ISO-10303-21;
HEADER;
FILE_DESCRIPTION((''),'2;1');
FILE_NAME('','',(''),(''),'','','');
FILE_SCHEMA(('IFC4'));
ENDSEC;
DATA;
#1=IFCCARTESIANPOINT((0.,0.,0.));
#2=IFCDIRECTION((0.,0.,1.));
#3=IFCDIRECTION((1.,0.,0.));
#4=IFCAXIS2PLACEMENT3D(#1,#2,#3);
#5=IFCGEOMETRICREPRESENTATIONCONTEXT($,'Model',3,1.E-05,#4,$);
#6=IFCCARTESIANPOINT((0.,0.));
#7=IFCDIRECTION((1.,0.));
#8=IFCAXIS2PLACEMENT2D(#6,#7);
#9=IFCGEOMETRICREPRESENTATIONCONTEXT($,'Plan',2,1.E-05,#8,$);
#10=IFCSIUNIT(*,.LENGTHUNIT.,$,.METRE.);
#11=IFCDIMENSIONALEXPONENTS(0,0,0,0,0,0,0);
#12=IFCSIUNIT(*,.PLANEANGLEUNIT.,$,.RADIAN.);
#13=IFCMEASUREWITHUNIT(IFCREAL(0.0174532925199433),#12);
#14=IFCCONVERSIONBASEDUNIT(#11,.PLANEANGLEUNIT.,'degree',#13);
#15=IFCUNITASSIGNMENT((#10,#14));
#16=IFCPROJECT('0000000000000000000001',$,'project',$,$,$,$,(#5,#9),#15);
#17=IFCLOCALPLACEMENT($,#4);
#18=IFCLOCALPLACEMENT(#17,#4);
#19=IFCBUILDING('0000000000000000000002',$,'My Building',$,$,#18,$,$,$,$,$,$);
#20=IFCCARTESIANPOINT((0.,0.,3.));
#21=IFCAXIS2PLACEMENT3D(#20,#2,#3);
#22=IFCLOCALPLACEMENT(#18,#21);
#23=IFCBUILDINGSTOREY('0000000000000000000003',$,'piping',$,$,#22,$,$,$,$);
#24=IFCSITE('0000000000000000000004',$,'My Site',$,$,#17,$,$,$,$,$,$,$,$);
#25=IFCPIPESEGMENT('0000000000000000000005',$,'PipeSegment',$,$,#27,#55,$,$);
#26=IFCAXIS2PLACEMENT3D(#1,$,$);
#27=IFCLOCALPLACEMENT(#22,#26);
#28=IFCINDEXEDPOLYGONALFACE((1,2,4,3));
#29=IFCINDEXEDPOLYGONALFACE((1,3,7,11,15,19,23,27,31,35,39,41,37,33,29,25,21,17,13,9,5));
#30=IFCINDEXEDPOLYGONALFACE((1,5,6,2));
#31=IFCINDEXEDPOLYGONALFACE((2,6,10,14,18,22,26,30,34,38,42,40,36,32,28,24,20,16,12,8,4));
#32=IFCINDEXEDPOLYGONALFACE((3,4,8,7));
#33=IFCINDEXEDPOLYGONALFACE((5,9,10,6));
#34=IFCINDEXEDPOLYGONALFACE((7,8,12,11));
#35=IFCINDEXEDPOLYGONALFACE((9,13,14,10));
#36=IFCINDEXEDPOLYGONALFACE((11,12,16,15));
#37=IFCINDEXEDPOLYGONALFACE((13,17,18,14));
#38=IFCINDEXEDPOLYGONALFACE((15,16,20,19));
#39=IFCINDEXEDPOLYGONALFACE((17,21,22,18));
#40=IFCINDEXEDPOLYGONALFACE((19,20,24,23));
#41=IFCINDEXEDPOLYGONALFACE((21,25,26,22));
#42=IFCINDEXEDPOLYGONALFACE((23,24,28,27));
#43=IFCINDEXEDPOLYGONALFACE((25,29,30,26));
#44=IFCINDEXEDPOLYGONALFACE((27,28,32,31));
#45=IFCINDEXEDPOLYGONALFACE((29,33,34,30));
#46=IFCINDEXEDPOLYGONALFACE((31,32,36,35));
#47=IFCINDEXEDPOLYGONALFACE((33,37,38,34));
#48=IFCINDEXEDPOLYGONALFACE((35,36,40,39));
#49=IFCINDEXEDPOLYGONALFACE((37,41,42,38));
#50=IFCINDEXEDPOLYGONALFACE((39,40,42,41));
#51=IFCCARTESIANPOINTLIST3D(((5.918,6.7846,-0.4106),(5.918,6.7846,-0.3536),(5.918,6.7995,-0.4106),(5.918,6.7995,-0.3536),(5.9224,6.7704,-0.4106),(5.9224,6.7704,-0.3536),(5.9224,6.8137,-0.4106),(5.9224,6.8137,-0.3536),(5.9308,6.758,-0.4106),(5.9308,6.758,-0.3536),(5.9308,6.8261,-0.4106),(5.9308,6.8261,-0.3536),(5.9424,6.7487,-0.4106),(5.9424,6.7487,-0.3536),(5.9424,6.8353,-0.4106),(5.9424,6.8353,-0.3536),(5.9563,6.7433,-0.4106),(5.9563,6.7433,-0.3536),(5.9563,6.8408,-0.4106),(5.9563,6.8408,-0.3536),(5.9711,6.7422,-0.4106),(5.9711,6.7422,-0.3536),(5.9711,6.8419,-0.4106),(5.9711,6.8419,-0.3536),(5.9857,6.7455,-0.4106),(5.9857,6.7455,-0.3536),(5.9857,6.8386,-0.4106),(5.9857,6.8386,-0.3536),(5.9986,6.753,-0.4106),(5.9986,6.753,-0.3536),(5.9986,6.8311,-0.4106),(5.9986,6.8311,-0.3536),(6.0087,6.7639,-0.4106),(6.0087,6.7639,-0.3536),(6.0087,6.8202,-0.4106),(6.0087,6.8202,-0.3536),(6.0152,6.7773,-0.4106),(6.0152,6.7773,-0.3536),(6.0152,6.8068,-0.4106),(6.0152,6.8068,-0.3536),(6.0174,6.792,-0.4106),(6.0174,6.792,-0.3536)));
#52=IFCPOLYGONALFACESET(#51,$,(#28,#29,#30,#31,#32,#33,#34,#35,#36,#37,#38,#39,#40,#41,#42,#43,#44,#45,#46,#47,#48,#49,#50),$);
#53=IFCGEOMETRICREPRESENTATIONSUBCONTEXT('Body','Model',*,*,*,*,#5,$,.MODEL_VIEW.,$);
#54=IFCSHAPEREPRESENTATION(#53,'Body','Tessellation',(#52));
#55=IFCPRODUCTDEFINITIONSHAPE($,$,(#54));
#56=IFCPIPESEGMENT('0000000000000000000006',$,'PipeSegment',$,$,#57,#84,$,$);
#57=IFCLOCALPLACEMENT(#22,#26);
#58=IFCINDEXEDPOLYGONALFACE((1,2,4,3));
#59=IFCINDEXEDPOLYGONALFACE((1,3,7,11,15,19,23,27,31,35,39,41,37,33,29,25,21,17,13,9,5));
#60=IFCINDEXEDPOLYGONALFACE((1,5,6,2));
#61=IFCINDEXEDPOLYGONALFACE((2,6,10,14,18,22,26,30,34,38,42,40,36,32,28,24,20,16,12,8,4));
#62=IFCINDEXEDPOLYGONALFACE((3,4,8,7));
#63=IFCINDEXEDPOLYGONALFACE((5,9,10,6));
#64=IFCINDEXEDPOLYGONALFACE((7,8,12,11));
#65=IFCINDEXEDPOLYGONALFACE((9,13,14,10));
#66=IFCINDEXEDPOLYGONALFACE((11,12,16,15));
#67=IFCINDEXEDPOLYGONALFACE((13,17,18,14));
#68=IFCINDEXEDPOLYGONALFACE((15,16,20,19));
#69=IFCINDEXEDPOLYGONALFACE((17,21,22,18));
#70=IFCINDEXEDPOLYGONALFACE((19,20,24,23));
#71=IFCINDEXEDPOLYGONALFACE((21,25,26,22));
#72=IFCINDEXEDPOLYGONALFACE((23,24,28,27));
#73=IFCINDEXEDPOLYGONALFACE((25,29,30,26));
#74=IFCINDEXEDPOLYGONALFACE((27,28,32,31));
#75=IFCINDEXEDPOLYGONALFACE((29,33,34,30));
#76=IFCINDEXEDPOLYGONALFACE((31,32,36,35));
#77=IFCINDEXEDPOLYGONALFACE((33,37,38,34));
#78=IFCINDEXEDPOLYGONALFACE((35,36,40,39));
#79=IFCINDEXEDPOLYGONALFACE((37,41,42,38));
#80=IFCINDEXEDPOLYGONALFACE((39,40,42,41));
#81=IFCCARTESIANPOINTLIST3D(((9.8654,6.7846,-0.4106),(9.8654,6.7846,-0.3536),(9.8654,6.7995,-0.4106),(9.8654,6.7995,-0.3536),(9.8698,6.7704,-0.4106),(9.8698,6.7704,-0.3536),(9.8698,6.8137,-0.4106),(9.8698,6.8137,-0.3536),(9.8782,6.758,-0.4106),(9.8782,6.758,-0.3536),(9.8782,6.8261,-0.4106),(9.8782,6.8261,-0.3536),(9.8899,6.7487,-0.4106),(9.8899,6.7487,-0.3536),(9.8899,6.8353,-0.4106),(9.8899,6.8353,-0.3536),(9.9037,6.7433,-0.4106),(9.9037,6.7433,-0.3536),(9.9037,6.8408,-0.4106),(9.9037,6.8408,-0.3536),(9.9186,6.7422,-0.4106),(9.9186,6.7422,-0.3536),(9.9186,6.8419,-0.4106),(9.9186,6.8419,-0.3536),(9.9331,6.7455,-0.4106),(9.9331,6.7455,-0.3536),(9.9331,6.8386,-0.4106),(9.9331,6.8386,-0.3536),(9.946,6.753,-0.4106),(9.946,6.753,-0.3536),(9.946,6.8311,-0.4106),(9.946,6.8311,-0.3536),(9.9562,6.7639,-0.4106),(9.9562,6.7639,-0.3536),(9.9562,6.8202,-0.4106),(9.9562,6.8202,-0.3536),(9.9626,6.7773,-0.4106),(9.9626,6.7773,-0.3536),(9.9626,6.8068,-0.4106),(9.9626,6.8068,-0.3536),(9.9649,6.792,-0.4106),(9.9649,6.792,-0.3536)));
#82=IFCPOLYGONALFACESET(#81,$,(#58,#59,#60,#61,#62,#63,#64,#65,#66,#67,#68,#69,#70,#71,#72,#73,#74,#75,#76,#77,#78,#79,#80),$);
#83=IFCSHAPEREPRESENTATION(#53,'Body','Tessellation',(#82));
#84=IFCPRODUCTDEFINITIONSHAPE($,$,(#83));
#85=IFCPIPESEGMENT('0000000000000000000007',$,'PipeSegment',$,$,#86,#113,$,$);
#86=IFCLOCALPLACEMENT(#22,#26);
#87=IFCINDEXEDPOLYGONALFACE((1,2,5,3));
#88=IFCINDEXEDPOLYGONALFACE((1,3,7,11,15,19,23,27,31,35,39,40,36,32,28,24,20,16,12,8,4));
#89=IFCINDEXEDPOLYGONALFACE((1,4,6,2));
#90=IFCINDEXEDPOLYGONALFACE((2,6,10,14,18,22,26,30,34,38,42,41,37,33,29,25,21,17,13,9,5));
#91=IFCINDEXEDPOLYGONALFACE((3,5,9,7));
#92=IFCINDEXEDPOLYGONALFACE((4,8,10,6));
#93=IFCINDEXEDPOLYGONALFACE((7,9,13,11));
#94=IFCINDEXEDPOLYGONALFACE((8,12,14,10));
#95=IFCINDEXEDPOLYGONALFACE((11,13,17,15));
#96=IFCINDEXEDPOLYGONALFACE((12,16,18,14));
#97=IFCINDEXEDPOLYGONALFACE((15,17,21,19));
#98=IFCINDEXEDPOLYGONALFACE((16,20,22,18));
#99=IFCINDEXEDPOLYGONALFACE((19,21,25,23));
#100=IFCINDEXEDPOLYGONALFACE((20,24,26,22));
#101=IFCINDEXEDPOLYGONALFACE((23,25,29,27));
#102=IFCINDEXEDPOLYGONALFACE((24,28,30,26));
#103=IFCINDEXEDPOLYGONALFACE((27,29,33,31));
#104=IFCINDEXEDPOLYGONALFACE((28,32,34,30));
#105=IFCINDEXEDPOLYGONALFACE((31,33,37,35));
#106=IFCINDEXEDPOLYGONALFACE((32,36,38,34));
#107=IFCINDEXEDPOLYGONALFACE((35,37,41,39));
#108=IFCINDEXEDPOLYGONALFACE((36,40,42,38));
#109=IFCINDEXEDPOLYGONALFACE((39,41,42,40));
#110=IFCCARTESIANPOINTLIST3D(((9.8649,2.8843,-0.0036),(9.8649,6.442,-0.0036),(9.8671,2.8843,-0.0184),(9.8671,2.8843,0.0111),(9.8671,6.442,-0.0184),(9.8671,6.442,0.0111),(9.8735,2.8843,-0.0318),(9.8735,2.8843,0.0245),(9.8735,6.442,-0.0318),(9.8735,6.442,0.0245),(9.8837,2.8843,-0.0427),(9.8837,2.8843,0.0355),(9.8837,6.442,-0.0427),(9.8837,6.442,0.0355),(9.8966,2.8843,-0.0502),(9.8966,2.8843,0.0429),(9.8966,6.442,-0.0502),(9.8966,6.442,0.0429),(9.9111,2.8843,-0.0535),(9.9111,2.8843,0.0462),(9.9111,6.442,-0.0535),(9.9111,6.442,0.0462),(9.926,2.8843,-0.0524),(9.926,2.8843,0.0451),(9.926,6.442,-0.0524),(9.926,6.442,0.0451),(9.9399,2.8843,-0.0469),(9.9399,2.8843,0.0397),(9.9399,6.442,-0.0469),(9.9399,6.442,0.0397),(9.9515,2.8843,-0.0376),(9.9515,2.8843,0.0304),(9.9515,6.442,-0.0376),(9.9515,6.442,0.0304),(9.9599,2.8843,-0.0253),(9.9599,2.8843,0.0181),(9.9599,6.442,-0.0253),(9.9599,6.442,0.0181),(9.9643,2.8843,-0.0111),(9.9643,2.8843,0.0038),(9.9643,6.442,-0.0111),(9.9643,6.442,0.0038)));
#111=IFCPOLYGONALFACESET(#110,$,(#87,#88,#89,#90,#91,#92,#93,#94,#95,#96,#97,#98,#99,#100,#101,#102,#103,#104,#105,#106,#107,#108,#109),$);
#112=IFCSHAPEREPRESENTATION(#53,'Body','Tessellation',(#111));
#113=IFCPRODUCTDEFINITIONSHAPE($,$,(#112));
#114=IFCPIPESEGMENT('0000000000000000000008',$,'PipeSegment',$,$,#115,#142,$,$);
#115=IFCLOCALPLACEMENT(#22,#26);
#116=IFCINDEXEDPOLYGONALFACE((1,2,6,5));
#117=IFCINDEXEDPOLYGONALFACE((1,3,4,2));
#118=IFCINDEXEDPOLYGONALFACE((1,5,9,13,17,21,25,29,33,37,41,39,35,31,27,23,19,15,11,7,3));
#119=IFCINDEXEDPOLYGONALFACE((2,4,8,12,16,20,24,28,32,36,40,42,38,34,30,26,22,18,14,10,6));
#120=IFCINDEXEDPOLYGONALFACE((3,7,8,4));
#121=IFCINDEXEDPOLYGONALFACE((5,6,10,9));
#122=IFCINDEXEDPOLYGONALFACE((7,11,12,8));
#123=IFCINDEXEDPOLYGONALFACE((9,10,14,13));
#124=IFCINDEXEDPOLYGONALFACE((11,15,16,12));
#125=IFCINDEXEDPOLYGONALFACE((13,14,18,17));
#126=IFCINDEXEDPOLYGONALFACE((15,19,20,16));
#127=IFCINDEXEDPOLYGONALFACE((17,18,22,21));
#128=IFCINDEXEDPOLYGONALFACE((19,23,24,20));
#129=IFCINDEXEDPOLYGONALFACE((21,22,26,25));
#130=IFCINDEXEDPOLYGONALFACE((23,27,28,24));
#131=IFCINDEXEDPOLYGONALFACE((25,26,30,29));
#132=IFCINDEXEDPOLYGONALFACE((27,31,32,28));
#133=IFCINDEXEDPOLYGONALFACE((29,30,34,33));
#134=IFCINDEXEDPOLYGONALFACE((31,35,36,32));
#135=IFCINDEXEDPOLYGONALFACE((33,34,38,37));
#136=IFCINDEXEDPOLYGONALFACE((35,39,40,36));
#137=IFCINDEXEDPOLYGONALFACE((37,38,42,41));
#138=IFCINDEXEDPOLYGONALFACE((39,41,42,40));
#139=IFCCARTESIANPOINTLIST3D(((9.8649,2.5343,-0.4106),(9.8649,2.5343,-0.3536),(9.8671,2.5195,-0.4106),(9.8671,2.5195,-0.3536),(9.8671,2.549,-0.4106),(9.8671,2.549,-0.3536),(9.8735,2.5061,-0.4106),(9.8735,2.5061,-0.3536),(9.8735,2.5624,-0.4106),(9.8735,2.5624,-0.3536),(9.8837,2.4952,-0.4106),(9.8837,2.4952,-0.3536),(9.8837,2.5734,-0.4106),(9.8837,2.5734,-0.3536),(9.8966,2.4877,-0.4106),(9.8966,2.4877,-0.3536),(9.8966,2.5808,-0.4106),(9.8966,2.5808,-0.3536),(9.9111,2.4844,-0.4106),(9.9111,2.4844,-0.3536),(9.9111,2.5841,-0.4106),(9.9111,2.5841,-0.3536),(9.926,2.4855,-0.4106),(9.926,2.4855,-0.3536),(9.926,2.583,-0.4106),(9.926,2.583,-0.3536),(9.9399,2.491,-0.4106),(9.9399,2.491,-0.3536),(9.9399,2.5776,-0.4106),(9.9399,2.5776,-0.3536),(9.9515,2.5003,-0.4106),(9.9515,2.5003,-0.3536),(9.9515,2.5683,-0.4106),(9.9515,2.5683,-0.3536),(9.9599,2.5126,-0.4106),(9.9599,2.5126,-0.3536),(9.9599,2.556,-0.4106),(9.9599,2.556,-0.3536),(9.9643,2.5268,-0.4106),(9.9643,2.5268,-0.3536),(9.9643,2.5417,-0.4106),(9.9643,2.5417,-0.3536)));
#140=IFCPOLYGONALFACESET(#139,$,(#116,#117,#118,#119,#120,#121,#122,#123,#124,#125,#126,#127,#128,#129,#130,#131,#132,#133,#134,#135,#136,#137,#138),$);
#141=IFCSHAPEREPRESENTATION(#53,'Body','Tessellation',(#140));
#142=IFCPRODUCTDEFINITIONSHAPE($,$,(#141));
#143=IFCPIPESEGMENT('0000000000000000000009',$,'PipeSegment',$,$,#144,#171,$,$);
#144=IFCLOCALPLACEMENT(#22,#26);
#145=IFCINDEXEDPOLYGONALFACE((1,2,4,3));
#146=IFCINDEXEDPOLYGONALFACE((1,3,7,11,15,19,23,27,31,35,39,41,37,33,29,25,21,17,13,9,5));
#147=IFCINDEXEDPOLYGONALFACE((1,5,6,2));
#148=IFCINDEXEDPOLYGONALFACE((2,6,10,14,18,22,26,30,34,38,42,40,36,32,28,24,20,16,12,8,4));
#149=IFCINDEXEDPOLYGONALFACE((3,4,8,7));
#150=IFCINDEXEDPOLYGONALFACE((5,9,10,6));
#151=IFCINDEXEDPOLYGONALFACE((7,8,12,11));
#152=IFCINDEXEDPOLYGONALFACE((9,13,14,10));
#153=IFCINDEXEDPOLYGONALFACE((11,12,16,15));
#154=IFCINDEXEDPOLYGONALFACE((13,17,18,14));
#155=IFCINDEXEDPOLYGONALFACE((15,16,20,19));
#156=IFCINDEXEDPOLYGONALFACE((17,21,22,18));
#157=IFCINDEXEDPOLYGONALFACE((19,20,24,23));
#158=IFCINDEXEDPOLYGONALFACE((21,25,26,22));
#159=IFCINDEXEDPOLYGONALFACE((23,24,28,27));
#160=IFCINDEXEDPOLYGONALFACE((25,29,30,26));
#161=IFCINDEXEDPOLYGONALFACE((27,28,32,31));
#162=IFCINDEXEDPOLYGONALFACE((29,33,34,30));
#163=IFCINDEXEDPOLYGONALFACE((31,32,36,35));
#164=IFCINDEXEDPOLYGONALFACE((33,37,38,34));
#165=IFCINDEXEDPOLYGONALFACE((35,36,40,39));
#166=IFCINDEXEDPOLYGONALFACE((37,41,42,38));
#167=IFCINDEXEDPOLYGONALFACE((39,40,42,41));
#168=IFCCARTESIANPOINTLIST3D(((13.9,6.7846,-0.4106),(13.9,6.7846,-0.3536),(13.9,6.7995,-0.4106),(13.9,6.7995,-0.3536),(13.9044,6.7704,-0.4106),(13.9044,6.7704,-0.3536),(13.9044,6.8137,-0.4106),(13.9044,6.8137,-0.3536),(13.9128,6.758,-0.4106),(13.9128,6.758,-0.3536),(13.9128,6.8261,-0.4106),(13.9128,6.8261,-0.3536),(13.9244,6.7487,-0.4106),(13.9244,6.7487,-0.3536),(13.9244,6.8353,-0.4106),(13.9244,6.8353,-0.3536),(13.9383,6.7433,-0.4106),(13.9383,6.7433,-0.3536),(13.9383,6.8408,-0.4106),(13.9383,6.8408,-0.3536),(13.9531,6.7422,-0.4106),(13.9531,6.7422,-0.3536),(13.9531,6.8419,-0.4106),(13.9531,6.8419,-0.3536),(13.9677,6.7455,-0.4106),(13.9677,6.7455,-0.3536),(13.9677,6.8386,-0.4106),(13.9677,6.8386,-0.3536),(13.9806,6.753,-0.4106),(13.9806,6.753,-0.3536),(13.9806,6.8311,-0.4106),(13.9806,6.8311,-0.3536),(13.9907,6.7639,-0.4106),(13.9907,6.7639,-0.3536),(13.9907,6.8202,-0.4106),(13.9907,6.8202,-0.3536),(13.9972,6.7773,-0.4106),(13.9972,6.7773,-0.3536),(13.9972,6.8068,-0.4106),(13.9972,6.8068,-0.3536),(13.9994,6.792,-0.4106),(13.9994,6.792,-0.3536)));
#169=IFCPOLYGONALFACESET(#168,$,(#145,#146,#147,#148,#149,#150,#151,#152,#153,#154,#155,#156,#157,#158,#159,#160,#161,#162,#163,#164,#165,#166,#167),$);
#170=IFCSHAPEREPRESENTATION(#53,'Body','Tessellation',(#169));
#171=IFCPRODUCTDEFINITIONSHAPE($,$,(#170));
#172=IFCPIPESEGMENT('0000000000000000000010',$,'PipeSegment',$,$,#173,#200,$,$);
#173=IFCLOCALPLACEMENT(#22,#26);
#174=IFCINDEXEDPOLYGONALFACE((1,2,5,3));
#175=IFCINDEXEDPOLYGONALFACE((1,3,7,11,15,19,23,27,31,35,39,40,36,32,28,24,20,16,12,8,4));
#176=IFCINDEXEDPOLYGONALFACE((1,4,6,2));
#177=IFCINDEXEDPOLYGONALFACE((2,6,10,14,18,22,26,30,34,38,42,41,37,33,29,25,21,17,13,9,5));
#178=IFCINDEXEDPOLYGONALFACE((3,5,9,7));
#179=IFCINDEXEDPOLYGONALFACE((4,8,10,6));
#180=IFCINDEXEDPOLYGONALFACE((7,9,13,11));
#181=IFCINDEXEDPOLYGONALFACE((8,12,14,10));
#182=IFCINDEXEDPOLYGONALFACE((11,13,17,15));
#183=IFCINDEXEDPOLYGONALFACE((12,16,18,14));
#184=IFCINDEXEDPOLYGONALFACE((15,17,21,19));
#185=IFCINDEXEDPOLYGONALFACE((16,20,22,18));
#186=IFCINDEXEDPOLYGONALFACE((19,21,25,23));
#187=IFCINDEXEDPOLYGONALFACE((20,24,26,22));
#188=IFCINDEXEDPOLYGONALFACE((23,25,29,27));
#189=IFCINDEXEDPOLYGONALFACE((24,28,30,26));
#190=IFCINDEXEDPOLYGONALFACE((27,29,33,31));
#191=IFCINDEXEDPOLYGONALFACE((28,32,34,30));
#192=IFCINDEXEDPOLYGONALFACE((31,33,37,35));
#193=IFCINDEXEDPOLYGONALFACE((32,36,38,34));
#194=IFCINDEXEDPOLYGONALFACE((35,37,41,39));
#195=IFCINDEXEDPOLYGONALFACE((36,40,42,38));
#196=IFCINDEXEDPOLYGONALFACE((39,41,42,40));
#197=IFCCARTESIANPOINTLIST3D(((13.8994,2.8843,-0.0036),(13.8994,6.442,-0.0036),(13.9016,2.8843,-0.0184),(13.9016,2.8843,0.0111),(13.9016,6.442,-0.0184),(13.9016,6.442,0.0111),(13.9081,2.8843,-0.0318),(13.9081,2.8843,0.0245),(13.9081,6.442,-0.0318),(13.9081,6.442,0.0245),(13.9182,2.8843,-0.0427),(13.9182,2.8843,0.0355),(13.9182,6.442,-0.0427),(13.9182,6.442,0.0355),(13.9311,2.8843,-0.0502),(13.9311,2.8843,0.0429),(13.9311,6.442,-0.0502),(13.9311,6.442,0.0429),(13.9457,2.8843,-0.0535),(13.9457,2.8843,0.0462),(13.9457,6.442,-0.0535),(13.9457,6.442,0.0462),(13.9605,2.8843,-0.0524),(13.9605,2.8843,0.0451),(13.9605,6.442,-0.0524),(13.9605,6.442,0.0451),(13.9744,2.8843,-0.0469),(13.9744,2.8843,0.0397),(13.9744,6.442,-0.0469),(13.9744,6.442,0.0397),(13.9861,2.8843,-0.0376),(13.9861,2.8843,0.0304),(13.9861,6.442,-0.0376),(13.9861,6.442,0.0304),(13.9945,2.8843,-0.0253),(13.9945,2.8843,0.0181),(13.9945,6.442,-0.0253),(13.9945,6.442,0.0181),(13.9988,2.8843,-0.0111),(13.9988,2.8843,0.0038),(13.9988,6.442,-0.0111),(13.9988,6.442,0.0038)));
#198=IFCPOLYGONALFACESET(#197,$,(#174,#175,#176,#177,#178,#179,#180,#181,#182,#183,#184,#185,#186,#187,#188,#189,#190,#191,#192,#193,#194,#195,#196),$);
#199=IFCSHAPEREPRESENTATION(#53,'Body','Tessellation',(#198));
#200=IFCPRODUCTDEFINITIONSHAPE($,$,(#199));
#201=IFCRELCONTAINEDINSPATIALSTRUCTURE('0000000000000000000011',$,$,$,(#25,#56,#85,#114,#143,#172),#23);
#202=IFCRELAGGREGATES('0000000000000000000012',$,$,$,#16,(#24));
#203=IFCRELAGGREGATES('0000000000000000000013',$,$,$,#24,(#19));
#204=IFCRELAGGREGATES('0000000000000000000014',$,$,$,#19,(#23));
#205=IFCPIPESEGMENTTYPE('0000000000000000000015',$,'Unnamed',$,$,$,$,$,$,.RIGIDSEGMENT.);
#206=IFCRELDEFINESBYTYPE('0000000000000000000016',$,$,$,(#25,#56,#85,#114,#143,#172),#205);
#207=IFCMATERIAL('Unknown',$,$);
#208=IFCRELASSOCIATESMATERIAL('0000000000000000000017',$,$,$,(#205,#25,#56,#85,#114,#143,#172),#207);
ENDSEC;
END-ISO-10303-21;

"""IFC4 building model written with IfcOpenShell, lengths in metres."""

from ifc_helpers import new_model, entity, si_unit, converted_unit, frame, origin_with_axes, origin_2d_with_axis, place, context, subcontext, project, spatial, circle, extrude, material, material_profile, profile_set, profile_usage, type_object, element, save


model = new_model("IFC4")

# Units and contexts
model_context = context("Model", 3, precision=1e-05, world=origin_with_axes())
plan_context = context("Plan", 2, precision=1e-05, world=origin_2d_with_axis())
body_context = subcontext(model_context, "Body", "Model", "MODEL_VIEW")
ifc_project = project(units=[si_unit("LENGTHUNIT", "METRE"), converted_unit("PLANEANGLEUNIT", "degree", entity("IfcReal", 0.0174532925199433), si_unit("PLANEANGLEUNIT", "RADIAN"), dimensions=[0, 0, 0, 0, 0, 0, 0])], contexts=[model_context, plan_context])

# Site, building, storey
site_placement = place(None, origin_with_axes())
site = spatial("IfcSite", under=ifc_project, at=site_placement, Name="My Site")
building_placement = place(site_placement, origin_with_axes())
building = spatial("IfcBuilding", under=site, at=building_placement, Name="My Building")
storey_placement = place(building_placement, frame((0.0, 0.0, 3.0), z_axis=(0.0, 0.0, 1.0), x_axis=(1.0, 0.0, 0.0)))
storey = spatial("IfcBuildingStorey", under=building, at=storey_placement, Name="piping")

# Pipe segments
ifc_material = material(Name="Unknown")
ifc_material_profile = material_profile(ifc_material, circle(Radius=0.05))
ifc_profile_set = profile_set([ifc_material_profile])
pipe_segment_type = type_object("IfcPipeSegmentType", Name="Unnamed", PredefinedType="RIGIDSEGMENT", material=ifc_profile_set)
ifc_profile_usage_1 = profile_usage(ifc_profile_set, cardinal=5)
pipe_segment_1_placement = place(storey_placement, frame((5.9674, 6.792, -0.3536), z_axis=(0.0, 0.0, -1.0), x_axis=(1.0, 0.0, 0.0)))
element("IfcPipeSegment", 1, at=pipe_segment_1_placement, inside=storey, type_object=pipe_segment_type, material=ifc_profile_usage_1, Name="PipeSegment", context=body_context, shape_type="SweptSolid", body=[
    extrude(circle(Radius=0.05), origin_with_axes(), (0.0, 0.0, 1.0), 0.057),
])
ifc_profile_usage_2 = profile_usage(ifc_profile_set, cardinal=5)
pipe_segment_2_placement = place(storey_placement, frame((9.9149, 6.792, -0.3536), z_axis=(0.0, 0.0, -1.0), x_axis=(1.0, 0.0, 0.0)))
element("IfcPipeSegment", 2, at=pipe_segment_2_placement, inside=storey, type_object=pipe_segment_type, material=ifc_profile_usage_2, Name="PipeSegment", context=body_context, shape_type="SweptSolid", body=[
    extrude(circle(Radius=0.05), origin_with_axes(), (0.0, 0.0, 1.0), 0.057),
])
ifc_profile_usage_3 = profile_usage(ifc_profile_set, cardinal=5)
pipe_segment_3_placement = place(storey_placement, frame((9.9149, 2.8843, -0.0036), z_axis=(0.0, 1.0, 0.0), x_axis=(-1.0, 0.0, 0.0)))
element("IfcPipeSegment", 3, at=pipe_segment_3_placement, inside=storey, type_object=pipe_segment_type, material=ifc_profile_usage_3, Name="PipeSegment", context=body_context, shape_type="SweptSolid", body=[
    extrude(circle(Radius=0.05), origin_with_axes(), (0.0, 0.0, 1.0), 3.5578),
])
ifc_profile_usage_4 = profile_usage(ifc_profile_set, cardinal=5)
pipe_segment_4_placement = place(storey_placement, frame((9.9149, 2.5343, -0.3536), z_axis=(0.0, 0.0, -1.0), x_axis=(-1.0, 0.0, 0.0)))
element("IfcPipeSegment", 4, at=pipe_segment_4_placement, inside=storey, type_object=pipe_segment_type, material=ifc_profile_usage_4, Name="PipeSegment", context=body_context, shape_type="SweptSolid", body=[
    extrude(circle(Radius=0.05), origin_with_axes(), (0.0, 0.0, 1.0), 0.057),
])
ifc_profile_usage_5 = profile_usage(ifc_profile_set, cardinal=5)
pipe_segment_5_placement = place(storey_placement, frame((13.9494, 6.792, -0.3536), z_axis=(0.0, 0.0, -1.0), x_axis=(1.0, 0.0, 0.0)))
element("IfcPipeSegment", 5, at=pipe_segment_5_placement, inside=storey, type_object=pipe_segment_type, material=ifc_profile_usage_5, Name="PipeSegment", context=body_context, shape_type="SweptSolid", body=[
    extrude(circle(Radius=0.05), origin_with_axes(), (0.0, 0.0, 1.0), 0.057),
])
ifc_profile_usage_6 = profile_usage(ifc_profile_set, cardinal=5)
pipe_segment_6_placement = place(storey_placement, frame((13.9494, 2.8843, -0.0036), z_axis=(0.0, 1.0, 0.0), x_axis=(-1.0, 0.0, 0.0)))
element("IfcPipeSegment", 6, at=pipe_segment_6_placement, inside=storey, type_object=pipe_segment_type, material=ifc_profile_usage_6, Name="PipeSegment", context=body_context, shape_type="SweptSolid", body=[
    extrude(circle(Radius=0.05), origin_with_axes(), (0.0, 0.0, 1.0), 3.5578),
])

save(model, "model.ifc")
